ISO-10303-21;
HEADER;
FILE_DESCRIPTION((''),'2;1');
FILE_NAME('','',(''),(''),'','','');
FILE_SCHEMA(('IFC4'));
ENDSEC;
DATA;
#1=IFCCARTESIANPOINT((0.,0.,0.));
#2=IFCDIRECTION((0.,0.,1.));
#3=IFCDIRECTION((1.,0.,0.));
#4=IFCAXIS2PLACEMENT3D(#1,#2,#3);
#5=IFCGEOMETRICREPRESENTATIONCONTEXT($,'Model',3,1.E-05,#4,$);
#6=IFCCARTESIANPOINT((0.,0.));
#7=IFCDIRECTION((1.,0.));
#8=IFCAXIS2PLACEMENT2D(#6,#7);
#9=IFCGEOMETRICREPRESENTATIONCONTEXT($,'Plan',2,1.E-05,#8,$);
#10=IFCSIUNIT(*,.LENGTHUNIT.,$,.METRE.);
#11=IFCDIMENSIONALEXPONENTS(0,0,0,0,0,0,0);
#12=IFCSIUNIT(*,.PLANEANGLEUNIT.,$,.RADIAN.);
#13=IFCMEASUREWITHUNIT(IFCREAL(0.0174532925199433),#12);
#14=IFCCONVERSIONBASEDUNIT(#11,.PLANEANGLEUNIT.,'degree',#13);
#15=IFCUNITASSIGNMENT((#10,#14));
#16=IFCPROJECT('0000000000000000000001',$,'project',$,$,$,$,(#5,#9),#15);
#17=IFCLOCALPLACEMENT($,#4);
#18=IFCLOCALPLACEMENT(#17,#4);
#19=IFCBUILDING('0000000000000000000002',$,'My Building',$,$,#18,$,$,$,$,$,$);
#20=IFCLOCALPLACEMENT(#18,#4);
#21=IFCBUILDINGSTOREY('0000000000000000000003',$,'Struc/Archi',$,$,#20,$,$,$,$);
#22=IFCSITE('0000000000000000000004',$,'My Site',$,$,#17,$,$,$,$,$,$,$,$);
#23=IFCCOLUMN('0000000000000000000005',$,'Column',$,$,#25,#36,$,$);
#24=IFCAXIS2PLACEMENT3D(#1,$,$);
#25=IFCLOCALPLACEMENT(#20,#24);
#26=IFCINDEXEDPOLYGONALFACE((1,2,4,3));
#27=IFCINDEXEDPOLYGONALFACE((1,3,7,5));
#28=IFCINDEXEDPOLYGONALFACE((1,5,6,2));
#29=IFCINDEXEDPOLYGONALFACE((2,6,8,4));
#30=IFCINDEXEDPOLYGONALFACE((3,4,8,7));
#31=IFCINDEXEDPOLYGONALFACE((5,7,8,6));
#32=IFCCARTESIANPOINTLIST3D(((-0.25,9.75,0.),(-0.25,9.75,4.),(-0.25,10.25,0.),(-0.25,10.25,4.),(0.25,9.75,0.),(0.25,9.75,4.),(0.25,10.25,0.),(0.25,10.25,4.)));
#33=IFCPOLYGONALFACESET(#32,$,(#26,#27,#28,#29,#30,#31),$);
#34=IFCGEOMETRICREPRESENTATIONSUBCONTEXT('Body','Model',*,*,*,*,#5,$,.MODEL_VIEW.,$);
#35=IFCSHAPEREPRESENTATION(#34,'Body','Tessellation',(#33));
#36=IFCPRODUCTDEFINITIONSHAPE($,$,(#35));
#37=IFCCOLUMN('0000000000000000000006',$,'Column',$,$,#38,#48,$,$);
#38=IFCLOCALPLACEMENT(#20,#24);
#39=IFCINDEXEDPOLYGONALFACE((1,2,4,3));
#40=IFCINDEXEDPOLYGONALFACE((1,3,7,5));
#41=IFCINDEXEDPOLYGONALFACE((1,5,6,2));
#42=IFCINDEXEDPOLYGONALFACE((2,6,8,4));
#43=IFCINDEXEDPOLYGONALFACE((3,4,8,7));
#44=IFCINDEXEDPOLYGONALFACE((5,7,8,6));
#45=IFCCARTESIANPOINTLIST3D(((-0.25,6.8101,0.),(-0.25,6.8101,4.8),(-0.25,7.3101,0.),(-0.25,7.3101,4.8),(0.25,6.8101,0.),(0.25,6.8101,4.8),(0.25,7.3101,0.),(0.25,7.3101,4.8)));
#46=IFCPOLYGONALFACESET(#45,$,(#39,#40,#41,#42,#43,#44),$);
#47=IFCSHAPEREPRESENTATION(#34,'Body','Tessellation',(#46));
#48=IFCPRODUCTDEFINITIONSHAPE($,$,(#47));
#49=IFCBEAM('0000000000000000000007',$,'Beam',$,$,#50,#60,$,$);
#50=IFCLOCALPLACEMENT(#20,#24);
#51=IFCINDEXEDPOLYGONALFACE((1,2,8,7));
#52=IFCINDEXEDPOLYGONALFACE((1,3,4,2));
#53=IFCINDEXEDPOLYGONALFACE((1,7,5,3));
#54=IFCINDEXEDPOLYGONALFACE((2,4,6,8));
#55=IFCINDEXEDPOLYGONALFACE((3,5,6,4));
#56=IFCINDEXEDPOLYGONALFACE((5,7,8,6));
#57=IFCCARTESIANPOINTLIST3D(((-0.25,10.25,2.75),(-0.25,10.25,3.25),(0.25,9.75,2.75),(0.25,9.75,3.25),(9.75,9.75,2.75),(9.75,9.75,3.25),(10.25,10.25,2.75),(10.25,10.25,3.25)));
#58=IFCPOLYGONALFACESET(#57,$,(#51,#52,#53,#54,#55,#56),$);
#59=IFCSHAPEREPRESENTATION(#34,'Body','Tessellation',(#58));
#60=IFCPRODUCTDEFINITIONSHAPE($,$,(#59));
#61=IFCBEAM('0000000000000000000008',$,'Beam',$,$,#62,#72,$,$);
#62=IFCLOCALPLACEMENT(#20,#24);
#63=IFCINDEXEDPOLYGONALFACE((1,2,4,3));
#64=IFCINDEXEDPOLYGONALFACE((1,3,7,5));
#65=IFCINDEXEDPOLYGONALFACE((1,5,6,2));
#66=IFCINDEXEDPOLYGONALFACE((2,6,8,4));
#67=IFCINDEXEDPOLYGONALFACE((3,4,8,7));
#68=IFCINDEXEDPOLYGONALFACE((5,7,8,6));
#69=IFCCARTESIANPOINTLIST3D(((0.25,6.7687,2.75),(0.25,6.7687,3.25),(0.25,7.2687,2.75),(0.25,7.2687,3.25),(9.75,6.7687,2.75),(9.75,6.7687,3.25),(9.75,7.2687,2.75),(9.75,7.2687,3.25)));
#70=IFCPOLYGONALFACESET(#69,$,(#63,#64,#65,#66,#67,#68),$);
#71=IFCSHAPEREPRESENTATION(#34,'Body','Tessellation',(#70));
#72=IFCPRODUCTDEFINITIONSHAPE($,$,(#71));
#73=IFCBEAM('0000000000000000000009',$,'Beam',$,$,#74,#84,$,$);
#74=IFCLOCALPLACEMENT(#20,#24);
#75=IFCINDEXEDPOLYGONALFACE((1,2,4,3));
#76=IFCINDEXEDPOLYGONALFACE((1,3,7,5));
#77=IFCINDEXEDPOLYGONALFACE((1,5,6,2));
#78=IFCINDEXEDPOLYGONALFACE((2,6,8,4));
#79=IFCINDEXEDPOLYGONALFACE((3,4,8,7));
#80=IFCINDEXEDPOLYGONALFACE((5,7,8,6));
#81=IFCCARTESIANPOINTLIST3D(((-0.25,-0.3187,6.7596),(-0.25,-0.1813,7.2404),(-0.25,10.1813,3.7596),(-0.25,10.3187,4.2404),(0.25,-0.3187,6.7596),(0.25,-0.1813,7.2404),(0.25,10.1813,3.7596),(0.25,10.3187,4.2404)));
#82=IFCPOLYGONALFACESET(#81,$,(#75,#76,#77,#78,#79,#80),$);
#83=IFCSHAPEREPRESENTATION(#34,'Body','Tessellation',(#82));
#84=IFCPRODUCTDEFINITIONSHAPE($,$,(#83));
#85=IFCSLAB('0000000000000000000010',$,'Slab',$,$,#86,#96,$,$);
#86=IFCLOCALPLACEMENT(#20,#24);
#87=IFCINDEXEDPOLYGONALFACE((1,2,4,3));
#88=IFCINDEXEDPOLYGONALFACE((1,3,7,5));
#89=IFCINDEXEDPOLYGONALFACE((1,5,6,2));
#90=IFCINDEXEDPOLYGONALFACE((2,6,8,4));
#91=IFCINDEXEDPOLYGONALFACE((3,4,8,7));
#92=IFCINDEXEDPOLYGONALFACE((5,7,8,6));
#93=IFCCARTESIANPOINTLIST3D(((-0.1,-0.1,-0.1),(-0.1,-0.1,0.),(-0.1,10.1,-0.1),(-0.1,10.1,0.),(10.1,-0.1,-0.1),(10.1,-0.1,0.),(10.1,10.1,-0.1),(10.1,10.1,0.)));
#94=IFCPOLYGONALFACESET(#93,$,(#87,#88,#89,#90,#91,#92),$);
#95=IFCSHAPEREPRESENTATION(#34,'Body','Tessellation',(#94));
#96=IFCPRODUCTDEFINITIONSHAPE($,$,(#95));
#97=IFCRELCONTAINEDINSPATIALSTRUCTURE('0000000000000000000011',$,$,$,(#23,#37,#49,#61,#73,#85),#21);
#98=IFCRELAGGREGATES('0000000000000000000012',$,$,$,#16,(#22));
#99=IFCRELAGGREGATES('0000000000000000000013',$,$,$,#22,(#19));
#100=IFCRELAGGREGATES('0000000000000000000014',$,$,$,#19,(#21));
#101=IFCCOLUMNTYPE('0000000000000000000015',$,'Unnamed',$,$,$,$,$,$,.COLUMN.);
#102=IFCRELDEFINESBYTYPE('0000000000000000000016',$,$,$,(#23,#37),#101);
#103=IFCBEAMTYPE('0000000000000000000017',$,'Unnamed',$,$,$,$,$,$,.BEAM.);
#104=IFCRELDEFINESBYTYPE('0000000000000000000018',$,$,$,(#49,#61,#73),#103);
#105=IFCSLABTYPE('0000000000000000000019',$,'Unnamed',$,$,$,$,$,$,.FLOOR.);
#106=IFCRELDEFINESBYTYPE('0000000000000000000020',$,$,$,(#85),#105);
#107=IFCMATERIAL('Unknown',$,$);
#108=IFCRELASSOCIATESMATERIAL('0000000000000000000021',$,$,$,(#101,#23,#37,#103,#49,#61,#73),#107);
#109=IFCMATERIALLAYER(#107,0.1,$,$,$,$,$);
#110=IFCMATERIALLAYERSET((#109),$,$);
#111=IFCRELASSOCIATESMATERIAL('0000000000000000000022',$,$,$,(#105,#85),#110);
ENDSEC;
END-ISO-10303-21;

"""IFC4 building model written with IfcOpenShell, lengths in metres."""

from ifc_helpers import new_model, entity, si_unit, converted_unit, frame, origin_with_axes, origin_2d_with_axis, place, context, subcontext, project, spatial, indexed_curve, rectangle, outline, extrude, clip, halfspace, material, layer, layer_set, layer_usage, material_profile, profile_set, profile_usage, type_object, element, save


model = new_model("IFC4")

# Units and contexts
model_context = context("Model", 3, precision=1e-05, world=origin_with_axes())
plan_context = context("Plan", 2, precision=1e-05, world=origin_2d_with_axis())
body_context_1 = subcontext(model_context, "Body", "Model", "MODEL_VIEW")
ifc_project = project(units=[si_unit("LENGTHUNIT", "METRE"), converted_unit("PLANEANGLEUNIT", "degree", entity("IfcReal", 0.0174532925199433), si_unit("PLANEANGLEUNIT", "RADIAN"), dimensions=[0, 0, 0, 0, 0, 0, 0])], contexts=[model_context, plan_context])

# Site, building, storey
site_placement = place(None, origin_with_axes())
site = spatial("IfcSite", under=ifc_project, at=site_placement, Name="My Site")
building_placement = place(site_placement, origin_with_axes())
building = spatial("IfcBuilding", under=site, at=building_placement, Name="My Building")
storey_placement = place(building_placement, origin_with_axes())
storey = spatial("IfcBuildingStorey", under=building, at=storey_placement, Name="Struc/Archi")

# Columns
ifc_material = material(Name="Unknown")
ifc_material_profile_1 = material_profile(ifc_material, rectangle(XDim=0.5, YDim=0.5))
ifc_profile_set_1 = profile_set([ifc_material_profile_1])
ifc_profile_usage_1 = profile_usage(ifc_profile_set_1, cardinal=5)
column_type = type_object("IfcColumnType", Name="Unnamed", PredefinedType="COLUMN", material=ifc_profile_set_1)
column_1_placement = place(storey_placement, frame((0.0, 10.0, 0.0), z_axis=(0.0, 0.0, 1.0), x_axis=(1.0, 0.0, 0.0)))
element("IfcColumn", 1, at=column_1_placement, inside=storey, type_object=column_type, material=ifc_profile_usage_1, Name="Column", context=body_context_1, shape_type="SweptSolid", body=[
    extrude(rectangle(XDim=0.5, YDim=0.5), origin_with_axes(), (0.0, 0.0, 1.0), 4.0),
])
ifc_profile_usage_2 = profile_usage(ifc_profile_set_1, cardinal=5)
column_2_placement = place(storey_placement, frame((0.0, 7.0601, 0.0), z_axis=(0.0, 0.0, 1.0), x_axis=(1.0, 0.0, 0.0)))
element("IfcColumn", 2, at=column_2_placement, inside=storey, type_object=column_type, material=ifc_profile_usage_2, Name="Column", context=body_context_1, shape_type="SweptSolid", body=[
    extrude(rectangle(XDim=0.5, YDim=0.5), origin_with_axes(), (0.0, 0.0, 1.0), 4.8),
])

# Beams
ifc_material_profile_2 = material_profile(ifc_material, rectangle(XDim=0.5, YDim=0.5))
ifc_profile_set_2 = profile_set([ifc_material_profile_2])
ifc_profile_usage_3 = profile_usage(ifc_profile_set_2, cardinal=5)
beam_type = type_object("IfcBeamType", Name="Unnamed", PredefinedType="BEAM", material=ifc_profile_set_2)
beam_1_placement = place(storey_placement, frame((-0.25, 10.0, 3.0), z_axis=(1.0, 0.0, 0.0), x_axis=(0.0, 1.0, 0.0)))
element("IfcBeam", 3, at=beam_1_placement, inside=storey, type_object=beam_type, material=ifc_profile_usage_3, Name="Beam", context=body_context_1, shape_type="Clipping", body=[
    clip(clip(extrude(rectangle(XDim=0.5, YDim=0.5), origin_with_axes(), (0.0, 0.0, 1.0), 10.5), halfspace(frame((0.25, -3.0, 10.5), z_axis=(-0.707107, 0.0, 0.707107), x_axis=(0.0, 1.0, 0.0)), False)), halfspace(frame((0.25, -3.0, 0.0), z_axis=(-0.707107, 0.0, -0.707107), x_axis=(0.0, 1.0, 0.0)), False)),
])
ifc_profile_usage_4 = profile_usage(ifc_profile_set_2, cardinal=5)
beam_2_placement = place(storey_placement, frame((0.25, 7.0187, 3.0), z_axis=(1.0, 0.0, 0.0), x_axis=(0.0, 1.0, 0.0)))
element("IfcBeam", 4, at=beam_2_placement, inside=storey, type_object=beam_type, material=ifc_profile_usage_4, Name="Beam", context=body_context_1, shape_type="SweptSolid", body=[
    extrude(rectangle(XDim=0.5, YDim=0.5), origin_with_axes(), (0.0, 0.0, 1.0), 9.5),
])
ifc_profile_usage_5 = profile_usage(ifc_profile_set_2, cardinal=5)
beam_3_placement = place(storey_placement, frame((0.0, 10.25, 4.0), z_axis=(0.0, -0.961524, 0.274721), x_axis=(1.0, 0.0, 0.0)))
element("IfcBeam", 5, at=beam_3_placement, inside=storey, type_object=beam_type, material=ifc_profile_usage_5, Name="Beam", context=body_context_1, shape_type="SweptSolid", body=[
    extrude(rectangle(XDim=0.5, YDim=0.5), origin_with_axes(), (0.0, 0.0, 1.0), 10.9202),
])

# Slab
ifc_layer_1 = layer(ifc_material, 0.1)
ifc_layer_set_1 = layer_set([ifc_layer_1])
ifc_layer_usage_1 = layer_usage(ifc_layer_set_1, "AXIS3", "POSITIVE", -0.1)
slab_type = type_object("IfcSlabType", Name="Unnamed", PredefinedType="FLOOR", material=ifc_layer_set_1)
slab_placement = place(storey_placement, frame((-0.1, 10.1, 0.0), z_axis=(0.0, 0.0, 1.0), x_axis=(1.0, 0.0, 0.0)))
element("IfcSlab", 6, at=slab_placement, inside=storey, type_object=slab_type, material=ifc_layer_usage_1, Name="Slab", context=body_context_1, shape_type="SweptSolid", body=[
    extrude(outline(indexed_curve([(0.0, 0.0), (10.2, 0.0), (10.2, -10.2), (0.0, -10.2), (0.0, 0.0)])), frame((0.0, 0.0, -0.1), z_axis=(0.0, 0.0, 1.0), x_axis=(1.0, 0.0, 0.0)), (0.0, 0.0, 1.0), 0.1),
])

save(model, "model.ifc")
